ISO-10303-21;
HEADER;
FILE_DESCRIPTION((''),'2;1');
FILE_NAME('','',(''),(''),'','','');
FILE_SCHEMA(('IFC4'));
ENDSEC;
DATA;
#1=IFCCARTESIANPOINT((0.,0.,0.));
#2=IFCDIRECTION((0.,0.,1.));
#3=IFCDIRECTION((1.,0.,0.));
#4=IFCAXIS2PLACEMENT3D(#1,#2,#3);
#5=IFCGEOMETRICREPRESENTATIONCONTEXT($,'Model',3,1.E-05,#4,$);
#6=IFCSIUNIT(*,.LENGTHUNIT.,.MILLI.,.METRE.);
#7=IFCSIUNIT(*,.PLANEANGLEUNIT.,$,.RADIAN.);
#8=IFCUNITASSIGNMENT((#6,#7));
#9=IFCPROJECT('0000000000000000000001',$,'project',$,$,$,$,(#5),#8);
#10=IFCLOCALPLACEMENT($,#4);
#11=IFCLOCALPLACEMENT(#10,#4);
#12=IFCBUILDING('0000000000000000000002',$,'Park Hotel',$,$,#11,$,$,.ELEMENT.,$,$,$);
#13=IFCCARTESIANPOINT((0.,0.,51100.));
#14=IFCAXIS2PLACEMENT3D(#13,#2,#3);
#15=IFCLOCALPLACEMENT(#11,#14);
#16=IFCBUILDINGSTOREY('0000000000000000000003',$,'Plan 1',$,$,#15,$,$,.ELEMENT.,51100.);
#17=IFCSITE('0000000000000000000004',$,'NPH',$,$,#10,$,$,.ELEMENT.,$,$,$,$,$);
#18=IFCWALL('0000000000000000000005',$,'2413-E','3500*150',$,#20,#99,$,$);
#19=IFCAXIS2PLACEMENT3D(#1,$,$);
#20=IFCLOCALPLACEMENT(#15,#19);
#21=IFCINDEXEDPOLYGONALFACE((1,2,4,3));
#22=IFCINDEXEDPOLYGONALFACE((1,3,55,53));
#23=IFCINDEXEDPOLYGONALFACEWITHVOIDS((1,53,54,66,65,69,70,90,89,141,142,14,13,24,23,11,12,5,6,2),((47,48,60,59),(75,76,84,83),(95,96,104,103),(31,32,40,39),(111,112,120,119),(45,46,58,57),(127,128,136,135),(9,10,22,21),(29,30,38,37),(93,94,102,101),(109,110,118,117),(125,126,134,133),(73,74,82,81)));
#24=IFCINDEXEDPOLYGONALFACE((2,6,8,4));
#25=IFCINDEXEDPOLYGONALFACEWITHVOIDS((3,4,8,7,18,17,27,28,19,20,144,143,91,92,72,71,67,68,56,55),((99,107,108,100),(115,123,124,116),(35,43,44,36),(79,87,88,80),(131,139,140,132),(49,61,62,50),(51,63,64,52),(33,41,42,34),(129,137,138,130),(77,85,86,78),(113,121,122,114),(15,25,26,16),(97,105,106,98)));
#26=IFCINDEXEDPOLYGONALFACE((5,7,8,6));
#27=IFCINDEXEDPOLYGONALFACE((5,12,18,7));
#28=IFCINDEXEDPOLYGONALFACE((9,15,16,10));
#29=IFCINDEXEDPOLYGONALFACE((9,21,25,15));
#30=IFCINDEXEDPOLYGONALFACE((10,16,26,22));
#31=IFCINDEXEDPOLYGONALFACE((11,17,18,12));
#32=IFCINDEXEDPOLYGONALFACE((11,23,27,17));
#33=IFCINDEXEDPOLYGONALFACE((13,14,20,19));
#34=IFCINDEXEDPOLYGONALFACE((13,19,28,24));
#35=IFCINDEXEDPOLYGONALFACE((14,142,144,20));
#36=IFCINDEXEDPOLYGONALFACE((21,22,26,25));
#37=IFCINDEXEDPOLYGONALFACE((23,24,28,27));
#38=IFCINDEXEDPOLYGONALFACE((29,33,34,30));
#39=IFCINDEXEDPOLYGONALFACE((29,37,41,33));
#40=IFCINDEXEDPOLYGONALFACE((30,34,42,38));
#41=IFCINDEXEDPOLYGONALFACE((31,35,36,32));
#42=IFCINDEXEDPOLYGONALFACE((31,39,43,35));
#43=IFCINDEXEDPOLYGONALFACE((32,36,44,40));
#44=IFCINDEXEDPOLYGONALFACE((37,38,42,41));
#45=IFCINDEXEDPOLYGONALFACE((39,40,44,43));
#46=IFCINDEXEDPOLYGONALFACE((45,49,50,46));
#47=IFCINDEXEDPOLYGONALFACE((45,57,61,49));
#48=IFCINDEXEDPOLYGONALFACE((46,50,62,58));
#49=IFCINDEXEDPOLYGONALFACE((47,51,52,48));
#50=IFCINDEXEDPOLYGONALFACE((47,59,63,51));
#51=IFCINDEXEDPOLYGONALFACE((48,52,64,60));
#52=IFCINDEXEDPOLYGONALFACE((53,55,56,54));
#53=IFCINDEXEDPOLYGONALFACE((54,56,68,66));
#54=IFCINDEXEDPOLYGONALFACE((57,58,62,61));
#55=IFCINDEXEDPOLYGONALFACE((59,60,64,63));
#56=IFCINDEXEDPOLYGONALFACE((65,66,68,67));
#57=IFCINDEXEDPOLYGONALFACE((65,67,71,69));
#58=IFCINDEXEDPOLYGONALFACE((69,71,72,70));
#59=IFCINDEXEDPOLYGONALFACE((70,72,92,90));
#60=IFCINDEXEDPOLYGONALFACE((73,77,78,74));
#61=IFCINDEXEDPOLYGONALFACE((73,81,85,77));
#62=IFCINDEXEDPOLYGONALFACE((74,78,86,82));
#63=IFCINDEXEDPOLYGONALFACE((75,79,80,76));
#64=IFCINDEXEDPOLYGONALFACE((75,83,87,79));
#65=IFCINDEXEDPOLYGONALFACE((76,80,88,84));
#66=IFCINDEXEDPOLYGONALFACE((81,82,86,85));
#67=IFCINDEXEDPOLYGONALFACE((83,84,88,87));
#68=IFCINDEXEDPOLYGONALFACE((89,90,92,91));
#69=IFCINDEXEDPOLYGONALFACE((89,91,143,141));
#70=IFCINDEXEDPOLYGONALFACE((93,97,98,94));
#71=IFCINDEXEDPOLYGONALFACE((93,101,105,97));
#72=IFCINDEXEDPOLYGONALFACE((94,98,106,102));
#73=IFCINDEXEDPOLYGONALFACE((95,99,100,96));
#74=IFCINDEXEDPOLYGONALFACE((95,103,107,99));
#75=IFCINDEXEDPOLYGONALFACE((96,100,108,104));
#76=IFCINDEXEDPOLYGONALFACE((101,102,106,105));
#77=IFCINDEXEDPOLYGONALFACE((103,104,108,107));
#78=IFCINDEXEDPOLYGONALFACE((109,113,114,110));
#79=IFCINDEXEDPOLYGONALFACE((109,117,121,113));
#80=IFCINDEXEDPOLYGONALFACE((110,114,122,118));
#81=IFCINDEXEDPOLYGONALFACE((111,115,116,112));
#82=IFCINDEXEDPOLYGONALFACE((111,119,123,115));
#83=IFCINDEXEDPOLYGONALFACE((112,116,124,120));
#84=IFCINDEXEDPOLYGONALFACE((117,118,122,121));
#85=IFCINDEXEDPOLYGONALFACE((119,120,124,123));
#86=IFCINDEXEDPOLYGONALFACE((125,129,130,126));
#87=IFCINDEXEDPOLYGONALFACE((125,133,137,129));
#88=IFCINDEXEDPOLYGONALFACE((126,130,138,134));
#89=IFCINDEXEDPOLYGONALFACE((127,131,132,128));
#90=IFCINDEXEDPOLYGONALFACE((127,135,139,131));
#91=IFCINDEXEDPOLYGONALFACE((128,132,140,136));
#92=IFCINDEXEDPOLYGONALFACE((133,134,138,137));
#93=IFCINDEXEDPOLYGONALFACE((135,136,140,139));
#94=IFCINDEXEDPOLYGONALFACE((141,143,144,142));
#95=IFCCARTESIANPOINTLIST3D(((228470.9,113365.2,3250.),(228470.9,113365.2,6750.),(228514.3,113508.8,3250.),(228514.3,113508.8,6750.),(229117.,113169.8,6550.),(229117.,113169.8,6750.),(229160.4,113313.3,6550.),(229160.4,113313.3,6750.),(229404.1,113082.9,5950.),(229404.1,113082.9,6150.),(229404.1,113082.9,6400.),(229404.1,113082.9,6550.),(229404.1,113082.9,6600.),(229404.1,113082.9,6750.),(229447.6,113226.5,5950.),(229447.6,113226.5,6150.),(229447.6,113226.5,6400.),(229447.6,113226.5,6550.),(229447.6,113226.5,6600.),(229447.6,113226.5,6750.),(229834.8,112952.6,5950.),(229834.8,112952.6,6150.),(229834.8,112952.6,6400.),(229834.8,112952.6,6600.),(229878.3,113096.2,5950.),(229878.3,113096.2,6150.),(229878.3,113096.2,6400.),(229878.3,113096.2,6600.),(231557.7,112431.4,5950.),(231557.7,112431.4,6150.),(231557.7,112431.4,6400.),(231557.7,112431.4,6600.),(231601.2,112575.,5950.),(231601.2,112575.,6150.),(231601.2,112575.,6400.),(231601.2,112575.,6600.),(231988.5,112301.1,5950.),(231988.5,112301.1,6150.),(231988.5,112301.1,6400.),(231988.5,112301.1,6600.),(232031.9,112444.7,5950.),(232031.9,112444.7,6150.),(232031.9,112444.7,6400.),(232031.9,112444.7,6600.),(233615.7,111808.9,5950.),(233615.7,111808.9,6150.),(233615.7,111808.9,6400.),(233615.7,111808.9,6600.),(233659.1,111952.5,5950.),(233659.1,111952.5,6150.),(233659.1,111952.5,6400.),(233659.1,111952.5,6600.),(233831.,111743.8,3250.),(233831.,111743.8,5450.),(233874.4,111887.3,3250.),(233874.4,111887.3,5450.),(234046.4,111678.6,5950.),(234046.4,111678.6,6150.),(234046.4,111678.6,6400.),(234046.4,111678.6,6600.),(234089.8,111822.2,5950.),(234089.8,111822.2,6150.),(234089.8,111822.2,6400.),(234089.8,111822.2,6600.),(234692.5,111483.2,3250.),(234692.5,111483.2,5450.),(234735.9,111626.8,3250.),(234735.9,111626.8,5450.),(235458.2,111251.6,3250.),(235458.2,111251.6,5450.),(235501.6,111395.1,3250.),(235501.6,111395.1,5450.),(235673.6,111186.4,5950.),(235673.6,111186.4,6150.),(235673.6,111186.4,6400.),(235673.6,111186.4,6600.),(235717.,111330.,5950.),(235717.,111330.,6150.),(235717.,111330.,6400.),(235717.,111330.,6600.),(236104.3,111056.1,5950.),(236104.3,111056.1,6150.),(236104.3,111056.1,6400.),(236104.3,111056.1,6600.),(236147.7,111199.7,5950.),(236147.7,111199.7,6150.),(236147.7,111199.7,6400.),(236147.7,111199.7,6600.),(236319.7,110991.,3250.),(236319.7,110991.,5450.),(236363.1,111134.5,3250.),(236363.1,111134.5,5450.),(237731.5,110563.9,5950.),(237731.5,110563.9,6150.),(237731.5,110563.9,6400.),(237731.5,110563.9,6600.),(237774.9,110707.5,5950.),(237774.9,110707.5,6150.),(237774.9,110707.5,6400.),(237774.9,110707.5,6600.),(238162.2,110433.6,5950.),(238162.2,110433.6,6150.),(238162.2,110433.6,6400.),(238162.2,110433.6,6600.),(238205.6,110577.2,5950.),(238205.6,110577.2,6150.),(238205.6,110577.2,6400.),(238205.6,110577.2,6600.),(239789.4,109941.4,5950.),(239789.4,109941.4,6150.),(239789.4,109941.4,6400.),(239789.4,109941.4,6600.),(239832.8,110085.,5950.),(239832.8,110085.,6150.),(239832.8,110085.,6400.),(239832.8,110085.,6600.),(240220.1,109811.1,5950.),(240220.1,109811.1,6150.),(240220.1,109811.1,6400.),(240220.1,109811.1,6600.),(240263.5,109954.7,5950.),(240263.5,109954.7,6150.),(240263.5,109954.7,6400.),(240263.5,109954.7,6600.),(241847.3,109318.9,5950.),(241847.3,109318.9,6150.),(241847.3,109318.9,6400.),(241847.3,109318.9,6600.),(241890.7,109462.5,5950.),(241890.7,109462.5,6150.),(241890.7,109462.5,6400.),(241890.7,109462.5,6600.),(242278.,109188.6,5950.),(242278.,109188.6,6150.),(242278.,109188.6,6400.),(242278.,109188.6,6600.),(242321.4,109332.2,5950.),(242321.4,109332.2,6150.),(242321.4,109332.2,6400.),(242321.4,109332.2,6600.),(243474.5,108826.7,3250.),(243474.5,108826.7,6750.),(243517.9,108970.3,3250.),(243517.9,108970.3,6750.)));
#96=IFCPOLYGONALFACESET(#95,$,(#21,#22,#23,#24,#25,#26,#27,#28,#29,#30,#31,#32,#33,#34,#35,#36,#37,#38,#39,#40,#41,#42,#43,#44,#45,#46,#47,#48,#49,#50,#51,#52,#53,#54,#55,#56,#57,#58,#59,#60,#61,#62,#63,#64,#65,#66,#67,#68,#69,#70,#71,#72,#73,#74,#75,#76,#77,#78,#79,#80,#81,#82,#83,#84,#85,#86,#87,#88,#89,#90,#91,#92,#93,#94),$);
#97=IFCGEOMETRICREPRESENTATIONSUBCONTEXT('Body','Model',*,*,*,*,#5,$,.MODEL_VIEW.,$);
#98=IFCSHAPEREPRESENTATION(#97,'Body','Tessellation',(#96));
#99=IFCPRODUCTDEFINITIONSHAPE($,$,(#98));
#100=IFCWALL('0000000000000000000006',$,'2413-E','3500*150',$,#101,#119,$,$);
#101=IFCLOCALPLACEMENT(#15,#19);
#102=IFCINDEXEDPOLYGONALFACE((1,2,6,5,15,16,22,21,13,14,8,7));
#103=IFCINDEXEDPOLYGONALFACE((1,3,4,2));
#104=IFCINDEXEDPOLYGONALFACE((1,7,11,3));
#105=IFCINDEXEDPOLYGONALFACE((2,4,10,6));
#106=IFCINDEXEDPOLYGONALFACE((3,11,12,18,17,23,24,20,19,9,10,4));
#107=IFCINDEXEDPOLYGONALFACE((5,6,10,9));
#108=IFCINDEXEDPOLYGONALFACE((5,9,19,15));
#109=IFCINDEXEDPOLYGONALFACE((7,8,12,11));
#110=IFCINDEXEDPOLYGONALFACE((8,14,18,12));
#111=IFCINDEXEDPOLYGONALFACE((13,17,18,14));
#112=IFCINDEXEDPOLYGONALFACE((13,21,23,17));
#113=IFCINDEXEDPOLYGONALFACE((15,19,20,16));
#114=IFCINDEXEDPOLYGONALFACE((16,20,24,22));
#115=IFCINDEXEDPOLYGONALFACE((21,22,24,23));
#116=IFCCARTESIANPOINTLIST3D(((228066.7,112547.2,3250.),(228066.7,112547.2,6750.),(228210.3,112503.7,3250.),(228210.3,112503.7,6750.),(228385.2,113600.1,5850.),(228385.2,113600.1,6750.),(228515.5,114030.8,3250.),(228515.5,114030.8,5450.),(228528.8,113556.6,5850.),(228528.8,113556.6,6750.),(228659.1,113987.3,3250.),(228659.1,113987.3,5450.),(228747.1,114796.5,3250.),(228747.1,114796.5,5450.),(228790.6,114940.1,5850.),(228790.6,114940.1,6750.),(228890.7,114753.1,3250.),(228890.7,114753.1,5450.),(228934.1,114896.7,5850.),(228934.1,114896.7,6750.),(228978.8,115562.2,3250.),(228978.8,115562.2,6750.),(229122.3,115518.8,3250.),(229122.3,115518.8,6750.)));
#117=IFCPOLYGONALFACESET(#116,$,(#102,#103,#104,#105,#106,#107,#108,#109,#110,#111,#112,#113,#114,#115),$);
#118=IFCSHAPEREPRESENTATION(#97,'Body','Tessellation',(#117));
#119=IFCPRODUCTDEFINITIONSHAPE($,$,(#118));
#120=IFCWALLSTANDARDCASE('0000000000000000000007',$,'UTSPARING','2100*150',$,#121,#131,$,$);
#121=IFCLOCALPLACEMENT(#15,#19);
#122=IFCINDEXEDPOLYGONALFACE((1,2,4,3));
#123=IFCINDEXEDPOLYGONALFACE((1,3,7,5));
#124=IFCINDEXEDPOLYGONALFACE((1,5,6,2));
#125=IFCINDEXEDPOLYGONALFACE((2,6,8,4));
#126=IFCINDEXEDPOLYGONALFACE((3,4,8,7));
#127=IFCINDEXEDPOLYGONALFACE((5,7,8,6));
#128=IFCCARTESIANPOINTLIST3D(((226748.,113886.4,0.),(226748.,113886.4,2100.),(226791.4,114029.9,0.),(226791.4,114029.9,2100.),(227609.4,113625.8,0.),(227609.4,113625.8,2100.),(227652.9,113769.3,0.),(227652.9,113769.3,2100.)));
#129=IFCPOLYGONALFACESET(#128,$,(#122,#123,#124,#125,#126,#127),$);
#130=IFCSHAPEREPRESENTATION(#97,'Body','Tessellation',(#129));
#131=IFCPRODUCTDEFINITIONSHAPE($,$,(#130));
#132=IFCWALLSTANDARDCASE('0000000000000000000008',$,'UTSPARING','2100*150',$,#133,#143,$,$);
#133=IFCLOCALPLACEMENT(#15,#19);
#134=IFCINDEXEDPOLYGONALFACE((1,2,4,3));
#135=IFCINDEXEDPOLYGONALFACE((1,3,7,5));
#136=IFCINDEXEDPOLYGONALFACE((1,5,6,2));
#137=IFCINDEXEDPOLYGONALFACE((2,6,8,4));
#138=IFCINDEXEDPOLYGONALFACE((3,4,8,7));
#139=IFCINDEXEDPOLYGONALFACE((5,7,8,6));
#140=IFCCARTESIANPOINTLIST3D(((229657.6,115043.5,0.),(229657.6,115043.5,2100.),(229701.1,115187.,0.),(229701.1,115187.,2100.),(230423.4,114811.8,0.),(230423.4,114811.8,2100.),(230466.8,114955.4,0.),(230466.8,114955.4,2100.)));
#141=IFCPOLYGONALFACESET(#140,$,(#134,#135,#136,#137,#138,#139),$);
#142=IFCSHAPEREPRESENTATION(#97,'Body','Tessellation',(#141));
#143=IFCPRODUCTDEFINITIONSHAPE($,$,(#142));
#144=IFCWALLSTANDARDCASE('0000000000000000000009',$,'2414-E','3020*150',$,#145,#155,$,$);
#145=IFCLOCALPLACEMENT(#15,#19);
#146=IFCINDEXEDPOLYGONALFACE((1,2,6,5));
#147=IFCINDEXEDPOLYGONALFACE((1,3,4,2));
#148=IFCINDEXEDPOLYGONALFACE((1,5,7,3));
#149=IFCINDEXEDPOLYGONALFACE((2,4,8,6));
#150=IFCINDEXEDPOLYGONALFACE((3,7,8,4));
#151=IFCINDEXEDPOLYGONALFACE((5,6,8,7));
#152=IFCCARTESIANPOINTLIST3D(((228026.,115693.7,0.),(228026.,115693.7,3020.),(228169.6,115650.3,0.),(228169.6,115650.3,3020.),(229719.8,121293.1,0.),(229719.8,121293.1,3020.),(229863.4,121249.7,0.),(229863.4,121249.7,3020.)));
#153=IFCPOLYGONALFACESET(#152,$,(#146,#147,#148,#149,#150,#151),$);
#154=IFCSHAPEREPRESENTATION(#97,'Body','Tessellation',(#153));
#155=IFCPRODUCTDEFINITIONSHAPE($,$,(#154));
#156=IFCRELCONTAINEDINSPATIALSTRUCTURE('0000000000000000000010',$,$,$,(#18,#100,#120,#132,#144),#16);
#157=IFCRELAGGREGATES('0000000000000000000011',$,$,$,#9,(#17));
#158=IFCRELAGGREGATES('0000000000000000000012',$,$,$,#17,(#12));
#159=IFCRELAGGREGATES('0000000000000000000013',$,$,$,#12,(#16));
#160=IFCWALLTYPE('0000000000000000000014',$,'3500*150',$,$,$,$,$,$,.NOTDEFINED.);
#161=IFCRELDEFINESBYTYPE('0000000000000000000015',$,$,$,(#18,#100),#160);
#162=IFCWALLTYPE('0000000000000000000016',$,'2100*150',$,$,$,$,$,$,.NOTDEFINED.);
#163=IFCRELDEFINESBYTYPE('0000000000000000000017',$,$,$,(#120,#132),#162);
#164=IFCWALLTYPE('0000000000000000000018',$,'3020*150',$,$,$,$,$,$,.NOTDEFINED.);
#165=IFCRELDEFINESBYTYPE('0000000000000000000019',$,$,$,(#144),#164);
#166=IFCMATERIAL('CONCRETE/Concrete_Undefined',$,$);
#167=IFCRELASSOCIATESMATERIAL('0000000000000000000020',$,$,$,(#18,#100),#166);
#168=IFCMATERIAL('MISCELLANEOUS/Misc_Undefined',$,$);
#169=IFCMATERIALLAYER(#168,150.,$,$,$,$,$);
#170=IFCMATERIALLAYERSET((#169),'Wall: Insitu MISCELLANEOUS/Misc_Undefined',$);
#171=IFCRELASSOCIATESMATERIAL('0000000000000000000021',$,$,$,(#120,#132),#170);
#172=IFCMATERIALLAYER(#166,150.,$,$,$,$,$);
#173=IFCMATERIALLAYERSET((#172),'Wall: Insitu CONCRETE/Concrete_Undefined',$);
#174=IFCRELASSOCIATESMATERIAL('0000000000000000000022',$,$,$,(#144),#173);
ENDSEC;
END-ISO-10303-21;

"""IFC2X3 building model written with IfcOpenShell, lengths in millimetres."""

from ifc_helpers import new_model, si_unit, frame, frame_2d, origin_with_axes, place, context, subcontext, project, spatial, rectangle, extrude, boolean, material, layer, layer_set, layer_usage, type_object, element, save


model = new_model("IFC2X3")

# Units and contexts
model_context = context("Model", 3, precision=1e-05, world=origin_with_axes())
body_context = subcontext(model_context, "Body", "Model", "MODEL_VIEW")
ifc_project = project(units=[si_unit("LENGTHUNIT", "METRE", prefix="MILLI"), si_unit("PLANEANGLEUNIT", "RADIAN")], contexts=[model_context])

# Site, building, storey
site_placement = place(None, origin_with_axes())
site = spatial("IfcSite", under=ifc_project, at=site_placement, Name="NPH", CompositionType="ELEMENT")
building_placement = place(site_placement, origin_with_axes())
building = spatial("IfcBuilding", under=site, at=building_placement, Name="Park Hotel", CompositionType="ELEMENT")
storey_placement = place(building_placement, frame((0.0, 0.0, 51100.0), z_axis=(0.0, 0.0, 1.0), x_axis=(1.0, 0.0, 0.0)))
storey = spatial("IfcBuildingStorey", under=building, at=storey_placement, Name="Plan 1", CompositionType="ELEMENT", Elevation=51100.0)

# Shared definitions
ifc_material_1 = material(Name="CONCRETE/Concrete_Undefined")

# Walls
ifc_layer_1 = layer(ifc_material_1, 150.0)
ifc_layer_set_1 = layer_set([ifc_layer_1], Name="Wall: Insitu CONCRETE/Concrete_Undefined")
wall_type_1 = type_object("IfcWallType", Name="3500*150", PredefinedType="NOTDEFINED")
wall_1_placement = place(storey_placement, frame((228492.6, 113437.0, 3250.0), z_axis=(0.0, 0.0, 1.0), x_axis=(0.957167, -0.289538, 0.0)))
solid_1 = boolean("DIFFERENCE", boolean("DIFFERENCE", boolean("DIFFERENCE", boolean("DIFFERENCE", boolean("DIFFERENCE", boolean("DIFFERENCE", boolean("DIFFERENCE", boolean("DIFFERENCE", extrude(rectangle(XDim=15675.0, YDim=150.0, at=frame_2d((0.0, 7837.5), x_axis=(0.0, -1.0))), frame((0.0, 0.0, 0.0), z_axis=(0.0, 0.0, 1.0), x_axis=(0.0, -1.0, 0.0)), (0.0, 0.0, 1.0), 3500.0), extrude(rectangle(XDim=450.0, YDim=200.0, at=frame_2d((0.0, 225.0), x_axis=(0.0, -1.0))), frame((13975.0, 25.0, 3150.0), z_axis=(0.0, 0.0, 1.0), x_axis=(-0.000006, -1.0, 0.0)), (0.0, 0.0, 1.0), 200.0)), extrude(rectangle(XDim=450.0, YDim=200.0, at=frame_2d((0.0, 225.0), x_axis=(0.0, -1.0))), frame((13975.0, 25.0, 2700.0), z_axis=(0.0, 0.0, 1.0), x_axis=(-0.000006, -1.0, 0.0)), (0.0, 0.0, 1.0), 200.0)), extrude(rectangle(XDim=450.0, YDim=200.0, at=frame_2d((0.0, 225.0), x_axis=(0.0, -1.0))), frame((11825.0, 25.0, 3150.0), z_axis=(0.0, 0.0, 1.0), x_axis=(-0.000006, -1.0, 0.0)), (0.0, 0.0, 1.0), 200.0)), extrude(rectangle(XDim=450.0, YDim=200.0, at=frame_2d((0.0, 225.0), x_axis=(0.0, -1.0))), frame((11825.0, 25.0, 2700.0), z_axis=(0.0, 0.0, 1.0), x_axis=(-0.000006, -1.0, 0.0)), (0.0, 0.0, 1.0), 200.0)), extrude(rectangle(XDim=450.0, YDim=200.0, at=frame_2d((0.0, 225.0), x_axis=(0.0, -1.0))), frame((9675.0, 25.0, 3150.0), z_axis=(0.0, 0.0, 1.0), x_axis=(-0.000006, -1.0, 0.0)), (0.0, 0.0, 1.0), 200.0)), extrude(rectangle(XDim=450.0, YDim=200.0, at=frame_2d((0.0, 225.0), x_axis=(0.0, -1.0))), frame((9675.0, 25.0, 2700.0), z_axis=(0.0, 0.0, 1.0), x_axis=(-0.000006, -1.0, 0.0)), (0.0, 0.0, 1.0), 200.0)), extrude(rectangle(XDim=450.0, YDim=200.0, at=frame_2d((0.0, 225.0), x_axis=(0.0, -1.0))), frame((7525.0, 25.0, 3150.0), z_axis=(0.0, 0.0, 1.0), x_axis=(-0.000006, -1.0, 0.0)), (0.0, 0.0, 1.0), 200.0)), extrude(rectangle(XDim=450.0, YDim=200.0, at=frame_2d((0.0, 225.0), x_axis=(0.0, -1.0))), frame((7525.0, 25.0, 2700.0), z_axis=(0.0, 0.0, 1.0), x_axis=(-0.000006, -1.0, 0.0)), (0.0, 0.0, 1.0), 200.0))
solid_2 = boolean("DIFFERENCE", boolean("DIFFERENCE", boolean("DIFFERENCE", boolean("DIFFERENCE", boolean("DIFFERENCE", boolean("DIFFERENCE", boolean("DIFFERENCE", boolean("DIFFERENCE", solid_1, extrude(rectangle(XDim=450.0, YDim=200.0, at=frame_2d((0.0, 225.0), x_axis=(0.0, -1.0))), frame((5375.0, 25.0, 3150.0), z_axis=(0.0, 0.0, 1.0), x_axis=(-0.000006, -1.0, 0.0)), (0.0, 0.0, 1.0), 200.0)), extrude(rectangle(XDim=450.0, YDim=200.0, at=frame_2d((0.0, 225.0), x_axis=(0.0, -1.0))), frame((5375.0, 25.0, 2700.0), z_axis=(0.0, 0.0, 1.0), x_axis=(-0.000006, -1.0, 0.0)), (0.0, 0.0, 1.0), 200.0)), extrude(rectangle(XDim=450.0, YDim=200.0, at=frame_2d((0.0, 225.0), x_axis=(0.0, -1.0))), frame((3225.0, 25.0, 3150.0), z_axis=(0.0, 0.0, 1.0), x_axis=(-0.000006, -1.0, 0.0)), (0.0, 0.0, 1.0), 200.0)), extrude(rectangle(XDim=450.0, YDim=200.0, at=frame_2d((0.0, 225.0), x_axis=(0.0, -1.0))), frame((975.0, 25.0, 3150.0), z_axis=(0.0, 0.0, 1.0), x_axis=(-0.000006, -1.0, 0.0)), (0.0, 0.0, 1.0), 200.0)), extrude(rectangle(XDim=450.0, YDim=200.0, at=frame_2d((0.0, 225.0), x_axis=(0.0, -1.0))), frame((3225.0, 25.0, 2700.0), z_axis=(0.0, 0.0, 1.0), x_axis=(-0.000006, -1.0, 0.0)), (0.0, 0.0, 1.0), 200.0)), extrude(rectangle(XDim=450.0, YDim=200.0, at=frame_2d((0.0, 225.0), x_axis=(0.0, -1.0))), frame((975.0, 25.0, 2700.0), z_axis=(0.0, 0.0, 1.0), x_axis=(-0.000006, -1.0, 0.0)), (0.0, 0.0, 1.0), 200.0)), extrude(rectangle(XDim=300.0, YDim=200.0, at=frame_2d((0.0, 150.0), x_axis=(0.0, -1.0))), frame((675.0, 25.0, 3300.0), z_axis=(0.0, 0.0, 1.0), x_axis=(-0.000011, -1.0, 0.0)), (0.0, 0.0, 1.0), 200.0)), extrude(rectangle(XDim=900.0, YDim=200.0, at=frame_2d((0.0, 450.0), x_axis=(0.0, -1.0))), frame((7300.0, 25.0, 0.0), z_axis=(0.0, 0.0, 1.0), x_axis=(-0.000003, -1.0, 0.0)), (0.0, 0.0, 1.0), 2200.0))
element("IfcWall", 1, at=wall_1_placement, inside=storey, type_object=wall_type_1, material=ifc_material_1, Name="2413-E", Description="3500*150", context=body_context, shape_type="CSG", body=[
    boolean("DIFFERENCE", solid_2, extrude(rectangle(XDim=900.0, YDim=200.0, at=frame_2d((0.0, 450.0), x_axis=(0.0, -1.0))), frame((5600.0, 25.0, 0.0), z_axis=(0.0, 0.0, 1.0), x_axis=(-0.000003, -1.0, 0.0)), (0.0, 0.0, 1.0), 2200.0)),
])
wall_2_placement = place(storey_placement, frame((228138.5, 112525.5, 3250.0), z_axis=(0.0, 0.0, 1.0), x_axis=(0.289537, 0.957167, 0.0)))
element("IfcWall", 2, at=wall_2_placement, inside=storey, type_object=wall_type_1, material=ifc_material_1, Name="2413-E", Description="3500*150", context=body_context, shape_type="CSG", body=[
    boolean("DIFFERENCE", boolean("DIFFERENCE", extrude(rectangle(XDim=3150.0, YDim=150.0, at=frame_2d((0.0, 1575.0), x_axis=(0.0, -1.0))), frame((0.0, 0.0, 0.0), z_axis=(0.0, 0.0, 1.0), x_axis=(0.0, -1.0, 0.0)), (0.0, 0.0, 1.0), 3500.0), extrude(rectangle(XDim=1400.0, YDim=200.0, at=frame_2d((0.0, 700.0), x_axis=(0.0, -1.0))), frame((2500.0, -25.0, 2600.0), z_axis=(0.0, 0.0, 1.0), x_axis=(0.000003, 1.0, 0.0)), (0.0, 0.0, 1.0), 900.0)), extrude(rectangle(XDim=800.0, YDim=200.0, at=frame_2d((0.0, 400.0), x_axis=(0.0, -1.0))), frame((2350.0, -25.0, 0.0), z_axis=(0.0, 0.0, 1.0), x_axis=(0.000006, 1.0, 0.0)), (0.0, 0.0, 1.0), 2200.0)),
])
ifc_material_2 = material(Name="MISCELLANEOUS/Misc_Undefined")
ifc_layer_2 = layer(ifc_material_2, 150.0)
ifc_layer_set_2 = layer_set([ifc_layer_2], Name="Wall: Insitu MISCELLANEOUS/Misc_Undefined")
ifc_layer_usage_1 = layer_usage(ifc_layer_set_2, "AXIS2", "POSITIVE", -75.0)
wall_type_2 = type_object("IfcWallType", Name="2100*150", PredefinedType="NOTDEFINED")
wall_3_placement = place(storey_placement, frame((226769.7, 113958.1, 0.0), z_axis=(0.0, 0.0, 1.0), x_axis=(0.957166, -0.289541, 0.0)))
element("IfcWallStandardCase", 3, at=wall_3_placement, inside=storey, type_object=wall_type_2, material=ifc_layer_usage_1, Name="UTSPARING", Description="2100*150", context=body_context, shape_type="SweptSolid", body=[
    extrude(rectangle(XDim=900.0, YDim=150.0, at=frame_2d((0.0, 450.0), x_axis=(0.0, -1.0))), frame((0.0, 0.0, 0.0), z_axis=(0.0, 0.0, 1.0), x_axis=(0.0, -1.0, 0.0)), (0.0, 0.0, 1.0), 2100.0),
])
ifc_layer_usage_2 = layer_usage(ifc_layer_set_2, "AXIS2", "POSITIVE", -75.0)
wall_4_placement = place(storey_placement, frame((229679.4, 115115.3, 0.0), z_axis=(0.0, 0.0, 1.0), x_axis=(0.957166, -0.289541, 0.0)))
element("IfcWallStandardCase", 4, at=wall_4_placement, inside=storey, type_object=wall_type_2, material=ifc_layer_usage_2, Name="UTSPARING", Description="2100*150", context=body_context, shape_type="SweptSolid", body=[
    extrude(rectangle(XDim=800.0, YDim=150.0, at=frame_2d((0.0, 400.0), x_axis=(0.0, -1.0))), frame((0.0, 0.0, 0.0), z_axis=(0.0, 0.0, 1.0), x_axis=(0.0, -1.0, 0.0)), (0.0, 0.0, 1.0), 2100.0),
])
ifc_layer_usage_3 = layer_usage(ifc_layer_set_1, "AXIS2", "POSITIVE", -75.0)
wall_type_3 = type_object("IfcWallType", Name="3020*150", PredefinedType="NOTDEFINED")
wall_5_placement = place(storey_placement, frame((228097.8, 115672.0, 0.0), z_axis=(0.0, 0.0, 1.0), x_axis=(0.289539, 0.957166, 0.0)))
element("IfcWallStandardCase", 5, at=wall_5_placement, inside=storey, type_object=wall_type_3, material=ifc_layer_usage_3, Name="2414-E", Description="3020*150", context=body_context, shape_type="SweptSolid", body=[
    extrude(rectangle(XDim=5850.0, YDim=150.0, at=frame_2d((0.0, 2925.0), x_axis=(0.0, -1.0))), frame((0.0, 0.0, 0.0), z_axis=(0.0, 0.0, 1.0), x_axis=(0.0, -1.0, 0.0)), (0.0, 0.0, 1.0), 3020.0),
])

save(model, "model.ifc")
